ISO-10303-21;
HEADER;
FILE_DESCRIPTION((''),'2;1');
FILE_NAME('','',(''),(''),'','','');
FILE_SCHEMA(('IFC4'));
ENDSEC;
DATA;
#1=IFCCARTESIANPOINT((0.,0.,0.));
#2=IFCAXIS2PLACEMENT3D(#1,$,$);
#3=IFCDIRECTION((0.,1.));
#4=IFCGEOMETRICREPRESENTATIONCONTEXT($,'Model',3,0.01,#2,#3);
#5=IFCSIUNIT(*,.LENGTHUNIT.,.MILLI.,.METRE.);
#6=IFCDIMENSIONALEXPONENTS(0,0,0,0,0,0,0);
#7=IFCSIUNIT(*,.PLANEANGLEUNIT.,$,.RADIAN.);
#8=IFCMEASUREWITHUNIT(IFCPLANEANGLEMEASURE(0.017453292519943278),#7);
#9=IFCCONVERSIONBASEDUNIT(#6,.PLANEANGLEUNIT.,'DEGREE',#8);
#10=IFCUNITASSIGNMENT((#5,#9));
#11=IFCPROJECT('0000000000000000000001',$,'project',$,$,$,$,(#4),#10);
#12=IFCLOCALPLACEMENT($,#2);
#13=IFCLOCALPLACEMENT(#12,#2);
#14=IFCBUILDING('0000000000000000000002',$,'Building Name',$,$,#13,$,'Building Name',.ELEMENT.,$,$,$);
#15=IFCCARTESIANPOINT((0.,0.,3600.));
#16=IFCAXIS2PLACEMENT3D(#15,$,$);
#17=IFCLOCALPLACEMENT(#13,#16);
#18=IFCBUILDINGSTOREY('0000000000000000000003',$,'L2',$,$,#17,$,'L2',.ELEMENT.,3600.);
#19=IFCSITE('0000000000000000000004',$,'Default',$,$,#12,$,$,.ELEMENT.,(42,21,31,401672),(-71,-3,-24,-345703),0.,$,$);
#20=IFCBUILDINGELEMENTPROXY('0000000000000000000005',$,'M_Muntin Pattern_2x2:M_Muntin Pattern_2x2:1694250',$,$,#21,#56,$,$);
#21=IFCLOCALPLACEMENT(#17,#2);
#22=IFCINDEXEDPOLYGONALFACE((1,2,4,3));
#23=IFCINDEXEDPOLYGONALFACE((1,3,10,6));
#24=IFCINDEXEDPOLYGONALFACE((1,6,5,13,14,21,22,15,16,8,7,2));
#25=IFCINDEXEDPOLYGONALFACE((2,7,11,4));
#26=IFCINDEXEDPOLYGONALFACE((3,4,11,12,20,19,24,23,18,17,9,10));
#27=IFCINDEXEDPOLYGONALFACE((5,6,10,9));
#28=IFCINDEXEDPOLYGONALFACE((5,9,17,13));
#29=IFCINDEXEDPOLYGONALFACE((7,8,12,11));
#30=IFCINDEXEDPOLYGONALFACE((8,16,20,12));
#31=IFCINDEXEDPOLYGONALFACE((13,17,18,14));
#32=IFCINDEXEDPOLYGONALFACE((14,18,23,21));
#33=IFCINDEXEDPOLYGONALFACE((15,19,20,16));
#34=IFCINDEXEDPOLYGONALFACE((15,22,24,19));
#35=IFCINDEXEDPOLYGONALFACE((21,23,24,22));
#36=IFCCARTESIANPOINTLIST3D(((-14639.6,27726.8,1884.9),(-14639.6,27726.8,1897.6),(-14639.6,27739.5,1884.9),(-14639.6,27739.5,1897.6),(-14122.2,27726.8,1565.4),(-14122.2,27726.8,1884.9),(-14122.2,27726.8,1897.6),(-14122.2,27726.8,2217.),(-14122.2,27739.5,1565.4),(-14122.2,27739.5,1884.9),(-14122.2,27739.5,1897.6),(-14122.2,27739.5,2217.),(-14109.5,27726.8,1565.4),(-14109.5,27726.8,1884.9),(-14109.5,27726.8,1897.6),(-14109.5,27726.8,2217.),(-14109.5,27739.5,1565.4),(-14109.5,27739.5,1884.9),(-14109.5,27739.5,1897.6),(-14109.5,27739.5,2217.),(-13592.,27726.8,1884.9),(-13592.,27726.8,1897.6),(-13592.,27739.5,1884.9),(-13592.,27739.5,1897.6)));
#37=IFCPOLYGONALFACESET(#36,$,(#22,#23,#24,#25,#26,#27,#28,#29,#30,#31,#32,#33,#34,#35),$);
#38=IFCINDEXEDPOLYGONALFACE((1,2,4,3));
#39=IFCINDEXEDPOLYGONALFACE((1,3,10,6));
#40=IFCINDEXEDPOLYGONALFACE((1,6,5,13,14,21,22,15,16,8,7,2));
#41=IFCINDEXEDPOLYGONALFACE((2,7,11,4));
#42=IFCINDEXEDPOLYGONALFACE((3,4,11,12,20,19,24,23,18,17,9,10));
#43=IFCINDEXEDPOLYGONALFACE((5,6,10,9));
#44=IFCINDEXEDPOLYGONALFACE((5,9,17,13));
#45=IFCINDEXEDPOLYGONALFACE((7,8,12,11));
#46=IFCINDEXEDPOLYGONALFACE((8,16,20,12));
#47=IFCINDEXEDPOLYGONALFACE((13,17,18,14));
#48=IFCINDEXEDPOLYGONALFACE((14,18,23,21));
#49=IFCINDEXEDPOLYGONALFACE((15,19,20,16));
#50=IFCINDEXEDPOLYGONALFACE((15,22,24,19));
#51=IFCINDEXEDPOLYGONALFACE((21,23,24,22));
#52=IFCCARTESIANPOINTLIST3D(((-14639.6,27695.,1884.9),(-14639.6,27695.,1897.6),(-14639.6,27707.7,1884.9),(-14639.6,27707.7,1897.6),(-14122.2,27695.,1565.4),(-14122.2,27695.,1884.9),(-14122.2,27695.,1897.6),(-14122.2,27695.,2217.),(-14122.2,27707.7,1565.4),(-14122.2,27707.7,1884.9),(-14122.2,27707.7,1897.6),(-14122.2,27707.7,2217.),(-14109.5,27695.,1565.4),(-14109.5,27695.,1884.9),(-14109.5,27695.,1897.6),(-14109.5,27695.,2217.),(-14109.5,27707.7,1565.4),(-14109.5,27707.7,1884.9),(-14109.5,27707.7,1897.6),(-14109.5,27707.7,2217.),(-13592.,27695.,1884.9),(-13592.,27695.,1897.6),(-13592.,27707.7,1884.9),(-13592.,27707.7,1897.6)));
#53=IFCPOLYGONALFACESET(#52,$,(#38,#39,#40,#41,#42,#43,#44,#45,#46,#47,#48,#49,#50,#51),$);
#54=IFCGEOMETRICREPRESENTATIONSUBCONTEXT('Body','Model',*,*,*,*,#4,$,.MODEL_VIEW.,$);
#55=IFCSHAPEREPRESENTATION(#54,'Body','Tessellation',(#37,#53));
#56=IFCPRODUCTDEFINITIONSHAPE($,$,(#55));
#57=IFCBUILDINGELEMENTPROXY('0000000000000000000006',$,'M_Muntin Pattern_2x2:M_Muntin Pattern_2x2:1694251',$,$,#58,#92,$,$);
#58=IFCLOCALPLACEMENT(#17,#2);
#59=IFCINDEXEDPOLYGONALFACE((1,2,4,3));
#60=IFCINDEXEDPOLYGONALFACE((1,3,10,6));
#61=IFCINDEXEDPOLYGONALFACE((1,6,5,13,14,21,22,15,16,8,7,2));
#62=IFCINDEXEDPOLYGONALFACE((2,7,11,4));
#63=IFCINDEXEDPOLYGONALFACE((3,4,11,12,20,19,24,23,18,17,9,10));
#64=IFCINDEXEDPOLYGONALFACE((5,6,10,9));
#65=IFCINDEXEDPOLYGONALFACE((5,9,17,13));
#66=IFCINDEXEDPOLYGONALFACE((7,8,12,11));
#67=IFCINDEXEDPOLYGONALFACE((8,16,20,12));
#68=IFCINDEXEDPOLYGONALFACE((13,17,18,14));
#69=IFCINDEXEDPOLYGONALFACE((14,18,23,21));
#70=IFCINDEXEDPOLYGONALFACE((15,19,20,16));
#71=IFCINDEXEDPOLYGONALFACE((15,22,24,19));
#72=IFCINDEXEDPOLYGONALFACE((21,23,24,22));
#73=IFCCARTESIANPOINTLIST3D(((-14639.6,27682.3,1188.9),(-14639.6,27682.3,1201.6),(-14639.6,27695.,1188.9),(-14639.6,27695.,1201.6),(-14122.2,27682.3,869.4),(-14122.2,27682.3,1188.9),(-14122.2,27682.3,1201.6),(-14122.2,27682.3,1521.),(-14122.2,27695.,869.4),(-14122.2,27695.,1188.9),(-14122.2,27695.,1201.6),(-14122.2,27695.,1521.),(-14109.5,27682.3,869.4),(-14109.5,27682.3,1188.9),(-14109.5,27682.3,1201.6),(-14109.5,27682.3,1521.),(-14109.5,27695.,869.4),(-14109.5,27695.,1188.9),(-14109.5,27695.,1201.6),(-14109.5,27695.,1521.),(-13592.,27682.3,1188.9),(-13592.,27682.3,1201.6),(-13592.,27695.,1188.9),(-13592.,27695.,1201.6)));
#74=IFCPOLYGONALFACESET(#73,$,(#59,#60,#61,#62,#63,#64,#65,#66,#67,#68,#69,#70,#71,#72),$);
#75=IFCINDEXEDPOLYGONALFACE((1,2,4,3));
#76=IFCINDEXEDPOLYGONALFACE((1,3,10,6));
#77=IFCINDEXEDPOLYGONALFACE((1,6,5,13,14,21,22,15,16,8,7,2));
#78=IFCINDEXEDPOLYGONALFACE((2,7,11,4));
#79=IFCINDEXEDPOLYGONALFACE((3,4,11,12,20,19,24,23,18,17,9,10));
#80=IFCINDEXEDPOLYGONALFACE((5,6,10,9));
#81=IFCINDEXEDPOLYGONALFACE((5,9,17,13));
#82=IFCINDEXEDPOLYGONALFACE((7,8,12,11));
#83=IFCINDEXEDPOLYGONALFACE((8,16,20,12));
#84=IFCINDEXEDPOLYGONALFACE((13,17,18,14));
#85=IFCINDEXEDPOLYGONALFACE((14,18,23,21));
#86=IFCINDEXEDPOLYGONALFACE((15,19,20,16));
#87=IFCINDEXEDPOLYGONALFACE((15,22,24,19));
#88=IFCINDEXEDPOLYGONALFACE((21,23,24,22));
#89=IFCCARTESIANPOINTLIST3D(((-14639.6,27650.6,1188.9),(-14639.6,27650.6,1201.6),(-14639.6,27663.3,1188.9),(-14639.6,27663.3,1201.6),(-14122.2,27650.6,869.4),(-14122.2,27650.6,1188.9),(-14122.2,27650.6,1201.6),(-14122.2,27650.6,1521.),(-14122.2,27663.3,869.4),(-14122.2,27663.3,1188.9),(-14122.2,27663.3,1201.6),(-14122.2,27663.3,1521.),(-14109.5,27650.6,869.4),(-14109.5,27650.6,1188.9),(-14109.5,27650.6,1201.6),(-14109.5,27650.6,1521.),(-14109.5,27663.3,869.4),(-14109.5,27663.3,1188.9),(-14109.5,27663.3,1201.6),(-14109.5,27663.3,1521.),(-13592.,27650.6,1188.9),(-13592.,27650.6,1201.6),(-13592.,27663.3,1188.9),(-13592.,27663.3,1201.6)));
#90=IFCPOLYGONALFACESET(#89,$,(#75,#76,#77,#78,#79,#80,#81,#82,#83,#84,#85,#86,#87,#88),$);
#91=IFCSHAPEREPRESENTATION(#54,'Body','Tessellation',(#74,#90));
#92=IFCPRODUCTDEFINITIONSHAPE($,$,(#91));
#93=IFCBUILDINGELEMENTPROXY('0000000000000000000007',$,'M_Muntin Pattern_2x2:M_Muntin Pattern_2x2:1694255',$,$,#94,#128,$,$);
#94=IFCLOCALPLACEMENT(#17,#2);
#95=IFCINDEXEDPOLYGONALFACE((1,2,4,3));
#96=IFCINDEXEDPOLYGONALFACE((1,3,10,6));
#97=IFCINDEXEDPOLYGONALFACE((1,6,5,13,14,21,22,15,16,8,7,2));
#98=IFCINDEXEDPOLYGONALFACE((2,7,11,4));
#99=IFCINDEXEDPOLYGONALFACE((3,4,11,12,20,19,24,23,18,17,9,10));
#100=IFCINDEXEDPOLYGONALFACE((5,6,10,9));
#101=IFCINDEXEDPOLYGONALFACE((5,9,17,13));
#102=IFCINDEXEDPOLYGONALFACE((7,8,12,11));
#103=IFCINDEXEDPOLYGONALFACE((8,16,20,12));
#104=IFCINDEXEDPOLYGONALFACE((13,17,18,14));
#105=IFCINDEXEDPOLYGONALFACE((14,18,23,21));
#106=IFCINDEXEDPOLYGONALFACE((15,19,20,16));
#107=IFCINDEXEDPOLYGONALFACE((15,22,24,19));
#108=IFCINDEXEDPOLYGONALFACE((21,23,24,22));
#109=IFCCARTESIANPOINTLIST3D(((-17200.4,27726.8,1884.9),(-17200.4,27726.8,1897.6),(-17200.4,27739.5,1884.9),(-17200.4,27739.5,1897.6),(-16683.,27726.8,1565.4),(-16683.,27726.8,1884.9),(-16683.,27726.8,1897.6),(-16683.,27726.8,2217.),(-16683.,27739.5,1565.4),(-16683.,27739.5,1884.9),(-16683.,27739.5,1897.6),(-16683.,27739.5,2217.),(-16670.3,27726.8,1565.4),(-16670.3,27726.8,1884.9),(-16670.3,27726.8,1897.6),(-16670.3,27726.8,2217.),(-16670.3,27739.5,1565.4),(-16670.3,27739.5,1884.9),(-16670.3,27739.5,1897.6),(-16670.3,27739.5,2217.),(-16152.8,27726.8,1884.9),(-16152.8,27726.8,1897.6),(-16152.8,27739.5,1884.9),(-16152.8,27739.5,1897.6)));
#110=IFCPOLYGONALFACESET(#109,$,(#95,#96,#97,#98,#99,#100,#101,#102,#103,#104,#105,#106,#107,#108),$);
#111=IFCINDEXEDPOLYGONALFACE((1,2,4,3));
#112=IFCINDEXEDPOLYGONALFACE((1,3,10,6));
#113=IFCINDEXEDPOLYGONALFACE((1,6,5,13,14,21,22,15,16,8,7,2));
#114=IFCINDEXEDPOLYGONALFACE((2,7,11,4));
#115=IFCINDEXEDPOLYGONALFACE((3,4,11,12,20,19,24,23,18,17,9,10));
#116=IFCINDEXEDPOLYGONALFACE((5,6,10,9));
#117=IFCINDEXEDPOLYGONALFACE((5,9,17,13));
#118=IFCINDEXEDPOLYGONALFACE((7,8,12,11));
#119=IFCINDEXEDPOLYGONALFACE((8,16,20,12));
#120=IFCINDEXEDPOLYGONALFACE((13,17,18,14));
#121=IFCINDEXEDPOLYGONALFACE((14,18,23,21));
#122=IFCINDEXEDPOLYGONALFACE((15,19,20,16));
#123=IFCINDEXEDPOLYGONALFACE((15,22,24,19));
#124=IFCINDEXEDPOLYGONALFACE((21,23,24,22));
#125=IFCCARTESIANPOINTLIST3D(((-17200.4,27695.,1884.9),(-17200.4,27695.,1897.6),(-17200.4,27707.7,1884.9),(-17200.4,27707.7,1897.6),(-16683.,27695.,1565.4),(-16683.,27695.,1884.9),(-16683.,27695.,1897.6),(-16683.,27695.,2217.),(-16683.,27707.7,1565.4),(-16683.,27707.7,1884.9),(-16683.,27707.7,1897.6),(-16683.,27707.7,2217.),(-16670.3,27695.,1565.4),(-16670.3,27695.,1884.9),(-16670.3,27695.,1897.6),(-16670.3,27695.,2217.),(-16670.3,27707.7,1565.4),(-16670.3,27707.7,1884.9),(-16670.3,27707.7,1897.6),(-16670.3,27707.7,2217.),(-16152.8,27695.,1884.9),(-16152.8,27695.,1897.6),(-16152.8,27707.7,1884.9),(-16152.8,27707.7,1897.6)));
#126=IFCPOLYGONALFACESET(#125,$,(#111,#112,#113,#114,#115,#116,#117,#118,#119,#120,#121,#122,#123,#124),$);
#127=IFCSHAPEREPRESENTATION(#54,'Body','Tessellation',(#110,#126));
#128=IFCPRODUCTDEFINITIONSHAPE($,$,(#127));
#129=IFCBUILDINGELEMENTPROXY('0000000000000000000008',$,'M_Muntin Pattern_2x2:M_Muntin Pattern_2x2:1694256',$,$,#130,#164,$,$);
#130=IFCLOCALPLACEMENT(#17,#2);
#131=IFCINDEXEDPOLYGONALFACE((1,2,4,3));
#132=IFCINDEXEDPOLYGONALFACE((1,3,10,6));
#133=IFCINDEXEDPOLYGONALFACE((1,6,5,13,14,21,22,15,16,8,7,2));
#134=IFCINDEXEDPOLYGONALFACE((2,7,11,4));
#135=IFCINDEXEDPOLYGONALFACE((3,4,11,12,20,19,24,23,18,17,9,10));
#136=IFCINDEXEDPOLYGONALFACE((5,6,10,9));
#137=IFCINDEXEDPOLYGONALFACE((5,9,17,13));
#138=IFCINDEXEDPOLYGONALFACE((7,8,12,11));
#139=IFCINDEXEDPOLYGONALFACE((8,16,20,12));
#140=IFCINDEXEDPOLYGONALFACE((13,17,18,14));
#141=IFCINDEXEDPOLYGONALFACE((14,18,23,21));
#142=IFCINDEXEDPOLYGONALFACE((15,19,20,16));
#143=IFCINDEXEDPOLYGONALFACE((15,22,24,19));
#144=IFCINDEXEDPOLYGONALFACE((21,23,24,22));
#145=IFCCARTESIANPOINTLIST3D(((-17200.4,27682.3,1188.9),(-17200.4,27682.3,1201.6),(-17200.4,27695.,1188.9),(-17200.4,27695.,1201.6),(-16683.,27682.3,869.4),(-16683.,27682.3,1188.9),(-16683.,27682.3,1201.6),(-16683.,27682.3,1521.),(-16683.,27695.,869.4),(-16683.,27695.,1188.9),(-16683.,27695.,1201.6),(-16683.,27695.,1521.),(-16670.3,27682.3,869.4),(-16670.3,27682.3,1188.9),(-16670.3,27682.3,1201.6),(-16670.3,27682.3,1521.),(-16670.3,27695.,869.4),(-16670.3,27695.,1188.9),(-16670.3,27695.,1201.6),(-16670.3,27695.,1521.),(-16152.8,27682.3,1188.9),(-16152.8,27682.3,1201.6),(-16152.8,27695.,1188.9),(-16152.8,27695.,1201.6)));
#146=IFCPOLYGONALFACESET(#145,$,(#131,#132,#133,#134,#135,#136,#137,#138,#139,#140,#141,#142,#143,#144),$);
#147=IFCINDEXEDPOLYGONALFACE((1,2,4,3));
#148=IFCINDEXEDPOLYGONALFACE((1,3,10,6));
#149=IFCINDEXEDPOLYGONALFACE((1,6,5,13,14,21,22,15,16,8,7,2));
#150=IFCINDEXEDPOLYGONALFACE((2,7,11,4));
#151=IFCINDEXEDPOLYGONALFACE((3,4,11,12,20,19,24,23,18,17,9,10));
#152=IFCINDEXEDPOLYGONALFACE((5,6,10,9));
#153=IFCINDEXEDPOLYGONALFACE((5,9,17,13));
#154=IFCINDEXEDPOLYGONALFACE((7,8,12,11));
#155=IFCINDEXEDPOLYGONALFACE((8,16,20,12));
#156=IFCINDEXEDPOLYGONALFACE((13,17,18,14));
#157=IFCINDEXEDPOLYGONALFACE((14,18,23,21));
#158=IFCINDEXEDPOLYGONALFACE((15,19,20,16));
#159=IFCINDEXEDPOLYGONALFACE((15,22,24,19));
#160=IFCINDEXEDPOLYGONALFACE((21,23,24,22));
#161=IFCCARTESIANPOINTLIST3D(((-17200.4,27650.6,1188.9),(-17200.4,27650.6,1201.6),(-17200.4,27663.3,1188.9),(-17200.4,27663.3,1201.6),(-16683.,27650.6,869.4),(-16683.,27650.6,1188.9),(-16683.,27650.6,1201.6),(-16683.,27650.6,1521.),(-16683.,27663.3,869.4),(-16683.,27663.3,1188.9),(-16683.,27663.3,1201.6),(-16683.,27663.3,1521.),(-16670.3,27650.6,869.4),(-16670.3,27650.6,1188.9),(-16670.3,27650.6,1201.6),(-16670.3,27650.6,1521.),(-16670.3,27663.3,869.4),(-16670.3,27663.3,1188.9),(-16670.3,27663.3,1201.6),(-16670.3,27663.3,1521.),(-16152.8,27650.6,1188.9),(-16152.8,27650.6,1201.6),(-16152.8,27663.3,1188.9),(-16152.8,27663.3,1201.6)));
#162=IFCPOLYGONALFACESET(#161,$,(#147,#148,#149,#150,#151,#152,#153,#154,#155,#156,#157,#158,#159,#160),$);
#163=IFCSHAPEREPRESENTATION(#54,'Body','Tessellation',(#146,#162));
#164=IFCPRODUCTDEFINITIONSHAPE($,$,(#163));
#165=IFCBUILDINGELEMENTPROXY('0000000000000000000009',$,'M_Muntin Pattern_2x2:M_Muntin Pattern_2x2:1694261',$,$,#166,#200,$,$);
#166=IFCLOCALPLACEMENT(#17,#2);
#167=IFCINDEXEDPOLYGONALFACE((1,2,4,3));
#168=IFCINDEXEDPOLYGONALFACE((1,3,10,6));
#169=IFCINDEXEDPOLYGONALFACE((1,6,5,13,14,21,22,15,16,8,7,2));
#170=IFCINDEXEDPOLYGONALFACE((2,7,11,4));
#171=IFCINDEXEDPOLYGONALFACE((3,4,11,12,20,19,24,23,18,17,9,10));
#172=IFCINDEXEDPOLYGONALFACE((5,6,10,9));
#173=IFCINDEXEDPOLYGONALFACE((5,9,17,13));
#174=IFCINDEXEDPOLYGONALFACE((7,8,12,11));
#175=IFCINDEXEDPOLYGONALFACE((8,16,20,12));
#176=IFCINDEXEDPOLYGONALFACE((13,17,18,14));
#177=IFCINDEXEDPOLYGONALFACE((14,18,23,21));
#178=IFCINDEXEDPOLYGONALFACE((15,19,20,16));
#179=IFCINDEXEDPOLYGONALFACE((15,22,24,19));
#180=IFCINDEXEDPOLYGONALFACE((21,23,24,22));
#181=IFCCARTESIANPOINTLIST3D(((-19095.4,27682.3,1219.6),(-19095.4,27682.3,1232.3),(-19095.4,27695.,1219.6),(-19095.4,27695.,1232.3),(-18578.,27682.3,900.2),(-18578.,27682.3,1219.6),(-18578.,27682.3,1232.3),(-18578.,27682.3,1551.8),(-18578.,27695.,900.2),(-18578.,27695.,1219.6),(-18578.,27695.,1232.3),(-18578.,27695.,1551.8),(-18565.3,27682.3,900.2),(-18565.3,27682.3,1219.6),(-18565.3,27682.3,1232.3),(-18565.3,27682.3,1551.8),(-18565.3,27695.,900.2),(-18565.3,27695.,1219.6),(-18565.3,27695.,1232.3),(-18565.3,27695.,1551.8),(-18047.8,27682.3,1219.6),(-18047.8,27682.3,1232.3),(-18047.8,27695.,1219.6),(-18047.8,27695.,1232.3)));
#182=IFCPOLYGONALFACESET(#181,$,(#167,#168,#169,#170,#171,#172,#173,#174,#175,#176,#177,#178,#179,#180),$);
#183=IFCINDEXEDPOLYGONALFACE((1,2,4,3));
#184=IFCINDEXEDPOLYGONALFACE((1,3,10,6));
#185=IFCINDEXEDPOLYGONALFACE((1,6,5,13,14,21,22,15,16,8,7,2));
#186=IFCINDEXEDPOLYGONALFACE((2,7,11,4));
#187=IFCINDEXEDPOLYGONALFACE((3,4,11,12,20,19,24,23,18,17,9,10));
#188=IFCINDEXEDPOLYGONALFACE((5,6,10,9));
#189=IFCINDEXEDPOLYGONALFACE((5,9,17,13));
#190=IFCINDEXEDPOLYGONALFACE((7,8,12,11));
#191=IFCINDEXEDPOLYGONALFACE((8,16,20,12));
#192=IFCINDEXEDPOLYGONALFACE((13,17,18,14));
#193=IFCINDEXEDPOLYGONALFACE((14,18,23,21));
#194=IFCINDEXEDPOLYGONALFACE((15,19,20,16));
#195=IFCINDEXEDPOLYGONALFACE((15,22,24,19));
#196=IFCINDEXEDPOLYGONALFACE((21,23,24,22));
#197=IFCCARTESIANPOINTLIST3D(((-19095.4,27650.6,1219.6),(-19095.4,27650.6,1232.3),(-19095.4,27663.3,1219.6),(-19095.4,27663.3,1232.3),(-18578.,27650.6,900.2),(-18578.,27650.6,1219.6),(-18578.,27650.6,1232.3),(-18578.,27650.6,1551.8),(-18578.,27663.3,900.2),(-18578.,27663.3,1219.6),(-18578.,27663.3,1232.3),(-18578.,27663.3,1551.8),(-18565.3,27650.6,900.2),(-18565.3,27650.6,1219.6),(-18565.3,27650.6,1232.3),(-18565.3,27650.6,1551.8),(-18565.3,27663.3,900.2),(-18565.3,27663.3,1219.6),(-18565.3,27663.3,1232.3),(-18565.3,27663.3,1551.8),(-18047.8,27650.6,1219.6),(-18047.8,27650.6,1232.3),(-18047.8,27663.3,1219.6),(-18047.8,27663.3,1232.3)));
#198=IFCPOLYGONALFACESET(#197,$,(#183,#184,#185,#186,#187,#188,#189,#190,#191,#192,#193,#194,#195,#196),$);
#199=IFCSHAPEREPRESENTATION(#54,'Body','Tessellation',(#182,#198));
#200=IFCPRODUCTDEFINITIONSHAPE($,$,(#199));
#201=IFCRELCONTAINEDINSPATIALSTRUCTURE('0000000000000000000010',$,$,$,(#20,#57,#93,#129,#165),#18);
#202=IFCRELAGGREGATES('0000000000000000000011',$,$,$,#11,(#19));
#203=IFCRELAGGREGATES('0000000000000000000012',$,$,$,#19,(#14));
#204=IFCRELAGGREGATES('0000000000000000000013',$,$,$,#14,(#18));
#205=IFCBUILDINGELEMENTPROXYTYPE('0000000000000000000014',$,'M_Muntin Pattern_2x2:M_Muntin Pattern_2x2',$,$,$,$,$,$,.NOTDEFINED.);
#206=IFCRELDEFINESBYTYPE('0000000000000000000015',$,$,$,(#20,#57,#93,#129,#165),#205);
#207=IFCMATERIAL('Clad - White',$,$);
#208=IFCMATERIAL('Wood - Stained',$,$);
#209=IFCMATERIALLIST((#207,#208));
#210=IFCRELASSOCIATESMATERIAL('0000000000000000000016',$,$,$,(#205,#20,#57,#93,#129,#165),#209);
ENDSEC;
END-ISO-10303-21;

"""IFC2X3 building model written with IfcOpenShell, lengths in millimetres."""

from ifc_helpers import new_model, entity, si_unit, converted_unit, direction, frame, origin, place, context, subcontext, project, spatial, polyline, outline, extrude, source, transform, mapped, material, material_list, type_object, type_shapes, element, save


model = new_model("IFC2X3")

# Units and contexts
model_context = context("Model", 3, precision=0.01, world=origin(), true_north=direction((0.0, 1.0)))
body_context = subcontext(model_context, "Body", "Model", "MODEL_VIEW")
ifc_project = project(units=[si_unit("LENGTHUNIT", "METRE", prefix="MILLI"), converted_unit("PLANEANGLEUNIT", "DEGREE", entity("IfcPlaneAngleMeasure", 0.017453292519943278), si_unit("PLANEANGLEUNIT", "RADIAN"), dimensions=[0, 0, 0, 0, 0, 0, 0])], contexts=[model_context])

# Site, building, storey
site_placement = place(None, origin())
site = spatial("IfcSite", under=ifc_project, at=site_placement, Name="Default", CompositionType="ELEMENT", RefLatitude=(42, 21, 31, 401672), RefLongitude=(-71, -3, -24, -345703), RefElevation=0.0)
building_placement = place(site_placement, origin())
building = spatial("IfcBuilding", under=site, at=building_placement, Name="Building Name", LongName="Building Name", CompositionType="ELEMENT")
storey_placement = place(building_placement, frame((0.0, 0.0, 3600.0)))
storey = spatial("IfcBuildingStorey", under=building, at=storey_placement, Name="L2", LongName="L2", CompositionType="ELEMENT", Elevation=3600.0)

# Shared definitions
ifc_material_1 = material(Name="Wood - Stained")

# Building element proxies
ifc_material_2 = material(Name="Clad - White")
ifc_material_list_1 = material_list([ifc_material_2, ifc_material_1])
building_element_proxy_type_1 = type_object("IfcBuildingElementProxyType", Name="M_Muntin Pattern_2x2:M_Muntin Pattern_2x2", PredefinedType="NOTDEFINED", material=ifc_material_list_1)
shared_shape_1 = source(origin(), body_context, "Body", "SweptSolid", [
    extrude(outline(polyline([(6.4, -6.4), (325.8, -6.4), (325.8, 6.3), (6.4, 6.3), (6.4, 523.8), (-6.3, 523.8), (-6.3, 6.3), (-325.8, 6.3), (-325.8, -6.4), (-6.3, -6.4), (-6.3, -523.8), (6.4, -523.8), (6.4, -6.4)])), frame((0.0, 9.5, 325.8), z_axis=(0.0, 1.0, 0.0), x_axis=(0.0, 0.0, 1.0)), (0.0, 0.0, 1.0), 12.7),
    extrude(outline(polyline([(6.4, -6.4), (325.8, -6.4), (325.8, 6.3), (6.4, 6.3), (6.4, 523.8), (-6.3, 523.8), (-6.3, 6.3), (-325.8, 6.3), (-325.8, -6.4), (-6.3, -6.4), (-6.3, -523.8), (6.4, -523.8), (6.4, -6.4)])), frame((0.0, -22.2, 325.8), z_axis=(0.0, 1.0, 0.0), x_axis=(0.0, 0.0, 1.0)), (0.0, 0.0, 1.0), 12.7),
])
type_shapes(building_element_proxy_type_1, [shared_shape_1])
for number, where, name in (
    (1, (-14115.8, 27717.2, 1565.4), "M_Muntin Pattern_2x2:M_Muntin Pattern_2x2:1694250"),
    (2, (-14115.8, 27672.8, 869.4), "M_Muntin Pattern_2x2:M_Muntin Pattern_2x2:1694251"),
    (3, (-16676.6, 27717.2, 1565.4), "M_Muntin Pattern_2x2:M_Muntin Pattern_2x2:1694255"),
    (4, (-16676.6, 27672.8, 869.4), "M_Muntin Pattern_2x2:M_Muntin Pattern_2x2:1694256"),
    (5, (-18571.6, 27672.8, 900.2), "M_Muntin Pattern_2x2:M_Muntin Pattern_2x2:1694261"),
):
    element("IfcBuildingElementProxy", number, at=place(storey_placement, frame(where)), inside=storey, type_object=building_element_proxy_type_1, material=ifc_material_list_1, Name=name, context=body_context, shape_type="MappedRepresentation", body=[
        mapped(shared_shape_1, transform((0.0, 0.0, 0.0), scale=1.0)),
    ])

save(model, "model.ifc")
